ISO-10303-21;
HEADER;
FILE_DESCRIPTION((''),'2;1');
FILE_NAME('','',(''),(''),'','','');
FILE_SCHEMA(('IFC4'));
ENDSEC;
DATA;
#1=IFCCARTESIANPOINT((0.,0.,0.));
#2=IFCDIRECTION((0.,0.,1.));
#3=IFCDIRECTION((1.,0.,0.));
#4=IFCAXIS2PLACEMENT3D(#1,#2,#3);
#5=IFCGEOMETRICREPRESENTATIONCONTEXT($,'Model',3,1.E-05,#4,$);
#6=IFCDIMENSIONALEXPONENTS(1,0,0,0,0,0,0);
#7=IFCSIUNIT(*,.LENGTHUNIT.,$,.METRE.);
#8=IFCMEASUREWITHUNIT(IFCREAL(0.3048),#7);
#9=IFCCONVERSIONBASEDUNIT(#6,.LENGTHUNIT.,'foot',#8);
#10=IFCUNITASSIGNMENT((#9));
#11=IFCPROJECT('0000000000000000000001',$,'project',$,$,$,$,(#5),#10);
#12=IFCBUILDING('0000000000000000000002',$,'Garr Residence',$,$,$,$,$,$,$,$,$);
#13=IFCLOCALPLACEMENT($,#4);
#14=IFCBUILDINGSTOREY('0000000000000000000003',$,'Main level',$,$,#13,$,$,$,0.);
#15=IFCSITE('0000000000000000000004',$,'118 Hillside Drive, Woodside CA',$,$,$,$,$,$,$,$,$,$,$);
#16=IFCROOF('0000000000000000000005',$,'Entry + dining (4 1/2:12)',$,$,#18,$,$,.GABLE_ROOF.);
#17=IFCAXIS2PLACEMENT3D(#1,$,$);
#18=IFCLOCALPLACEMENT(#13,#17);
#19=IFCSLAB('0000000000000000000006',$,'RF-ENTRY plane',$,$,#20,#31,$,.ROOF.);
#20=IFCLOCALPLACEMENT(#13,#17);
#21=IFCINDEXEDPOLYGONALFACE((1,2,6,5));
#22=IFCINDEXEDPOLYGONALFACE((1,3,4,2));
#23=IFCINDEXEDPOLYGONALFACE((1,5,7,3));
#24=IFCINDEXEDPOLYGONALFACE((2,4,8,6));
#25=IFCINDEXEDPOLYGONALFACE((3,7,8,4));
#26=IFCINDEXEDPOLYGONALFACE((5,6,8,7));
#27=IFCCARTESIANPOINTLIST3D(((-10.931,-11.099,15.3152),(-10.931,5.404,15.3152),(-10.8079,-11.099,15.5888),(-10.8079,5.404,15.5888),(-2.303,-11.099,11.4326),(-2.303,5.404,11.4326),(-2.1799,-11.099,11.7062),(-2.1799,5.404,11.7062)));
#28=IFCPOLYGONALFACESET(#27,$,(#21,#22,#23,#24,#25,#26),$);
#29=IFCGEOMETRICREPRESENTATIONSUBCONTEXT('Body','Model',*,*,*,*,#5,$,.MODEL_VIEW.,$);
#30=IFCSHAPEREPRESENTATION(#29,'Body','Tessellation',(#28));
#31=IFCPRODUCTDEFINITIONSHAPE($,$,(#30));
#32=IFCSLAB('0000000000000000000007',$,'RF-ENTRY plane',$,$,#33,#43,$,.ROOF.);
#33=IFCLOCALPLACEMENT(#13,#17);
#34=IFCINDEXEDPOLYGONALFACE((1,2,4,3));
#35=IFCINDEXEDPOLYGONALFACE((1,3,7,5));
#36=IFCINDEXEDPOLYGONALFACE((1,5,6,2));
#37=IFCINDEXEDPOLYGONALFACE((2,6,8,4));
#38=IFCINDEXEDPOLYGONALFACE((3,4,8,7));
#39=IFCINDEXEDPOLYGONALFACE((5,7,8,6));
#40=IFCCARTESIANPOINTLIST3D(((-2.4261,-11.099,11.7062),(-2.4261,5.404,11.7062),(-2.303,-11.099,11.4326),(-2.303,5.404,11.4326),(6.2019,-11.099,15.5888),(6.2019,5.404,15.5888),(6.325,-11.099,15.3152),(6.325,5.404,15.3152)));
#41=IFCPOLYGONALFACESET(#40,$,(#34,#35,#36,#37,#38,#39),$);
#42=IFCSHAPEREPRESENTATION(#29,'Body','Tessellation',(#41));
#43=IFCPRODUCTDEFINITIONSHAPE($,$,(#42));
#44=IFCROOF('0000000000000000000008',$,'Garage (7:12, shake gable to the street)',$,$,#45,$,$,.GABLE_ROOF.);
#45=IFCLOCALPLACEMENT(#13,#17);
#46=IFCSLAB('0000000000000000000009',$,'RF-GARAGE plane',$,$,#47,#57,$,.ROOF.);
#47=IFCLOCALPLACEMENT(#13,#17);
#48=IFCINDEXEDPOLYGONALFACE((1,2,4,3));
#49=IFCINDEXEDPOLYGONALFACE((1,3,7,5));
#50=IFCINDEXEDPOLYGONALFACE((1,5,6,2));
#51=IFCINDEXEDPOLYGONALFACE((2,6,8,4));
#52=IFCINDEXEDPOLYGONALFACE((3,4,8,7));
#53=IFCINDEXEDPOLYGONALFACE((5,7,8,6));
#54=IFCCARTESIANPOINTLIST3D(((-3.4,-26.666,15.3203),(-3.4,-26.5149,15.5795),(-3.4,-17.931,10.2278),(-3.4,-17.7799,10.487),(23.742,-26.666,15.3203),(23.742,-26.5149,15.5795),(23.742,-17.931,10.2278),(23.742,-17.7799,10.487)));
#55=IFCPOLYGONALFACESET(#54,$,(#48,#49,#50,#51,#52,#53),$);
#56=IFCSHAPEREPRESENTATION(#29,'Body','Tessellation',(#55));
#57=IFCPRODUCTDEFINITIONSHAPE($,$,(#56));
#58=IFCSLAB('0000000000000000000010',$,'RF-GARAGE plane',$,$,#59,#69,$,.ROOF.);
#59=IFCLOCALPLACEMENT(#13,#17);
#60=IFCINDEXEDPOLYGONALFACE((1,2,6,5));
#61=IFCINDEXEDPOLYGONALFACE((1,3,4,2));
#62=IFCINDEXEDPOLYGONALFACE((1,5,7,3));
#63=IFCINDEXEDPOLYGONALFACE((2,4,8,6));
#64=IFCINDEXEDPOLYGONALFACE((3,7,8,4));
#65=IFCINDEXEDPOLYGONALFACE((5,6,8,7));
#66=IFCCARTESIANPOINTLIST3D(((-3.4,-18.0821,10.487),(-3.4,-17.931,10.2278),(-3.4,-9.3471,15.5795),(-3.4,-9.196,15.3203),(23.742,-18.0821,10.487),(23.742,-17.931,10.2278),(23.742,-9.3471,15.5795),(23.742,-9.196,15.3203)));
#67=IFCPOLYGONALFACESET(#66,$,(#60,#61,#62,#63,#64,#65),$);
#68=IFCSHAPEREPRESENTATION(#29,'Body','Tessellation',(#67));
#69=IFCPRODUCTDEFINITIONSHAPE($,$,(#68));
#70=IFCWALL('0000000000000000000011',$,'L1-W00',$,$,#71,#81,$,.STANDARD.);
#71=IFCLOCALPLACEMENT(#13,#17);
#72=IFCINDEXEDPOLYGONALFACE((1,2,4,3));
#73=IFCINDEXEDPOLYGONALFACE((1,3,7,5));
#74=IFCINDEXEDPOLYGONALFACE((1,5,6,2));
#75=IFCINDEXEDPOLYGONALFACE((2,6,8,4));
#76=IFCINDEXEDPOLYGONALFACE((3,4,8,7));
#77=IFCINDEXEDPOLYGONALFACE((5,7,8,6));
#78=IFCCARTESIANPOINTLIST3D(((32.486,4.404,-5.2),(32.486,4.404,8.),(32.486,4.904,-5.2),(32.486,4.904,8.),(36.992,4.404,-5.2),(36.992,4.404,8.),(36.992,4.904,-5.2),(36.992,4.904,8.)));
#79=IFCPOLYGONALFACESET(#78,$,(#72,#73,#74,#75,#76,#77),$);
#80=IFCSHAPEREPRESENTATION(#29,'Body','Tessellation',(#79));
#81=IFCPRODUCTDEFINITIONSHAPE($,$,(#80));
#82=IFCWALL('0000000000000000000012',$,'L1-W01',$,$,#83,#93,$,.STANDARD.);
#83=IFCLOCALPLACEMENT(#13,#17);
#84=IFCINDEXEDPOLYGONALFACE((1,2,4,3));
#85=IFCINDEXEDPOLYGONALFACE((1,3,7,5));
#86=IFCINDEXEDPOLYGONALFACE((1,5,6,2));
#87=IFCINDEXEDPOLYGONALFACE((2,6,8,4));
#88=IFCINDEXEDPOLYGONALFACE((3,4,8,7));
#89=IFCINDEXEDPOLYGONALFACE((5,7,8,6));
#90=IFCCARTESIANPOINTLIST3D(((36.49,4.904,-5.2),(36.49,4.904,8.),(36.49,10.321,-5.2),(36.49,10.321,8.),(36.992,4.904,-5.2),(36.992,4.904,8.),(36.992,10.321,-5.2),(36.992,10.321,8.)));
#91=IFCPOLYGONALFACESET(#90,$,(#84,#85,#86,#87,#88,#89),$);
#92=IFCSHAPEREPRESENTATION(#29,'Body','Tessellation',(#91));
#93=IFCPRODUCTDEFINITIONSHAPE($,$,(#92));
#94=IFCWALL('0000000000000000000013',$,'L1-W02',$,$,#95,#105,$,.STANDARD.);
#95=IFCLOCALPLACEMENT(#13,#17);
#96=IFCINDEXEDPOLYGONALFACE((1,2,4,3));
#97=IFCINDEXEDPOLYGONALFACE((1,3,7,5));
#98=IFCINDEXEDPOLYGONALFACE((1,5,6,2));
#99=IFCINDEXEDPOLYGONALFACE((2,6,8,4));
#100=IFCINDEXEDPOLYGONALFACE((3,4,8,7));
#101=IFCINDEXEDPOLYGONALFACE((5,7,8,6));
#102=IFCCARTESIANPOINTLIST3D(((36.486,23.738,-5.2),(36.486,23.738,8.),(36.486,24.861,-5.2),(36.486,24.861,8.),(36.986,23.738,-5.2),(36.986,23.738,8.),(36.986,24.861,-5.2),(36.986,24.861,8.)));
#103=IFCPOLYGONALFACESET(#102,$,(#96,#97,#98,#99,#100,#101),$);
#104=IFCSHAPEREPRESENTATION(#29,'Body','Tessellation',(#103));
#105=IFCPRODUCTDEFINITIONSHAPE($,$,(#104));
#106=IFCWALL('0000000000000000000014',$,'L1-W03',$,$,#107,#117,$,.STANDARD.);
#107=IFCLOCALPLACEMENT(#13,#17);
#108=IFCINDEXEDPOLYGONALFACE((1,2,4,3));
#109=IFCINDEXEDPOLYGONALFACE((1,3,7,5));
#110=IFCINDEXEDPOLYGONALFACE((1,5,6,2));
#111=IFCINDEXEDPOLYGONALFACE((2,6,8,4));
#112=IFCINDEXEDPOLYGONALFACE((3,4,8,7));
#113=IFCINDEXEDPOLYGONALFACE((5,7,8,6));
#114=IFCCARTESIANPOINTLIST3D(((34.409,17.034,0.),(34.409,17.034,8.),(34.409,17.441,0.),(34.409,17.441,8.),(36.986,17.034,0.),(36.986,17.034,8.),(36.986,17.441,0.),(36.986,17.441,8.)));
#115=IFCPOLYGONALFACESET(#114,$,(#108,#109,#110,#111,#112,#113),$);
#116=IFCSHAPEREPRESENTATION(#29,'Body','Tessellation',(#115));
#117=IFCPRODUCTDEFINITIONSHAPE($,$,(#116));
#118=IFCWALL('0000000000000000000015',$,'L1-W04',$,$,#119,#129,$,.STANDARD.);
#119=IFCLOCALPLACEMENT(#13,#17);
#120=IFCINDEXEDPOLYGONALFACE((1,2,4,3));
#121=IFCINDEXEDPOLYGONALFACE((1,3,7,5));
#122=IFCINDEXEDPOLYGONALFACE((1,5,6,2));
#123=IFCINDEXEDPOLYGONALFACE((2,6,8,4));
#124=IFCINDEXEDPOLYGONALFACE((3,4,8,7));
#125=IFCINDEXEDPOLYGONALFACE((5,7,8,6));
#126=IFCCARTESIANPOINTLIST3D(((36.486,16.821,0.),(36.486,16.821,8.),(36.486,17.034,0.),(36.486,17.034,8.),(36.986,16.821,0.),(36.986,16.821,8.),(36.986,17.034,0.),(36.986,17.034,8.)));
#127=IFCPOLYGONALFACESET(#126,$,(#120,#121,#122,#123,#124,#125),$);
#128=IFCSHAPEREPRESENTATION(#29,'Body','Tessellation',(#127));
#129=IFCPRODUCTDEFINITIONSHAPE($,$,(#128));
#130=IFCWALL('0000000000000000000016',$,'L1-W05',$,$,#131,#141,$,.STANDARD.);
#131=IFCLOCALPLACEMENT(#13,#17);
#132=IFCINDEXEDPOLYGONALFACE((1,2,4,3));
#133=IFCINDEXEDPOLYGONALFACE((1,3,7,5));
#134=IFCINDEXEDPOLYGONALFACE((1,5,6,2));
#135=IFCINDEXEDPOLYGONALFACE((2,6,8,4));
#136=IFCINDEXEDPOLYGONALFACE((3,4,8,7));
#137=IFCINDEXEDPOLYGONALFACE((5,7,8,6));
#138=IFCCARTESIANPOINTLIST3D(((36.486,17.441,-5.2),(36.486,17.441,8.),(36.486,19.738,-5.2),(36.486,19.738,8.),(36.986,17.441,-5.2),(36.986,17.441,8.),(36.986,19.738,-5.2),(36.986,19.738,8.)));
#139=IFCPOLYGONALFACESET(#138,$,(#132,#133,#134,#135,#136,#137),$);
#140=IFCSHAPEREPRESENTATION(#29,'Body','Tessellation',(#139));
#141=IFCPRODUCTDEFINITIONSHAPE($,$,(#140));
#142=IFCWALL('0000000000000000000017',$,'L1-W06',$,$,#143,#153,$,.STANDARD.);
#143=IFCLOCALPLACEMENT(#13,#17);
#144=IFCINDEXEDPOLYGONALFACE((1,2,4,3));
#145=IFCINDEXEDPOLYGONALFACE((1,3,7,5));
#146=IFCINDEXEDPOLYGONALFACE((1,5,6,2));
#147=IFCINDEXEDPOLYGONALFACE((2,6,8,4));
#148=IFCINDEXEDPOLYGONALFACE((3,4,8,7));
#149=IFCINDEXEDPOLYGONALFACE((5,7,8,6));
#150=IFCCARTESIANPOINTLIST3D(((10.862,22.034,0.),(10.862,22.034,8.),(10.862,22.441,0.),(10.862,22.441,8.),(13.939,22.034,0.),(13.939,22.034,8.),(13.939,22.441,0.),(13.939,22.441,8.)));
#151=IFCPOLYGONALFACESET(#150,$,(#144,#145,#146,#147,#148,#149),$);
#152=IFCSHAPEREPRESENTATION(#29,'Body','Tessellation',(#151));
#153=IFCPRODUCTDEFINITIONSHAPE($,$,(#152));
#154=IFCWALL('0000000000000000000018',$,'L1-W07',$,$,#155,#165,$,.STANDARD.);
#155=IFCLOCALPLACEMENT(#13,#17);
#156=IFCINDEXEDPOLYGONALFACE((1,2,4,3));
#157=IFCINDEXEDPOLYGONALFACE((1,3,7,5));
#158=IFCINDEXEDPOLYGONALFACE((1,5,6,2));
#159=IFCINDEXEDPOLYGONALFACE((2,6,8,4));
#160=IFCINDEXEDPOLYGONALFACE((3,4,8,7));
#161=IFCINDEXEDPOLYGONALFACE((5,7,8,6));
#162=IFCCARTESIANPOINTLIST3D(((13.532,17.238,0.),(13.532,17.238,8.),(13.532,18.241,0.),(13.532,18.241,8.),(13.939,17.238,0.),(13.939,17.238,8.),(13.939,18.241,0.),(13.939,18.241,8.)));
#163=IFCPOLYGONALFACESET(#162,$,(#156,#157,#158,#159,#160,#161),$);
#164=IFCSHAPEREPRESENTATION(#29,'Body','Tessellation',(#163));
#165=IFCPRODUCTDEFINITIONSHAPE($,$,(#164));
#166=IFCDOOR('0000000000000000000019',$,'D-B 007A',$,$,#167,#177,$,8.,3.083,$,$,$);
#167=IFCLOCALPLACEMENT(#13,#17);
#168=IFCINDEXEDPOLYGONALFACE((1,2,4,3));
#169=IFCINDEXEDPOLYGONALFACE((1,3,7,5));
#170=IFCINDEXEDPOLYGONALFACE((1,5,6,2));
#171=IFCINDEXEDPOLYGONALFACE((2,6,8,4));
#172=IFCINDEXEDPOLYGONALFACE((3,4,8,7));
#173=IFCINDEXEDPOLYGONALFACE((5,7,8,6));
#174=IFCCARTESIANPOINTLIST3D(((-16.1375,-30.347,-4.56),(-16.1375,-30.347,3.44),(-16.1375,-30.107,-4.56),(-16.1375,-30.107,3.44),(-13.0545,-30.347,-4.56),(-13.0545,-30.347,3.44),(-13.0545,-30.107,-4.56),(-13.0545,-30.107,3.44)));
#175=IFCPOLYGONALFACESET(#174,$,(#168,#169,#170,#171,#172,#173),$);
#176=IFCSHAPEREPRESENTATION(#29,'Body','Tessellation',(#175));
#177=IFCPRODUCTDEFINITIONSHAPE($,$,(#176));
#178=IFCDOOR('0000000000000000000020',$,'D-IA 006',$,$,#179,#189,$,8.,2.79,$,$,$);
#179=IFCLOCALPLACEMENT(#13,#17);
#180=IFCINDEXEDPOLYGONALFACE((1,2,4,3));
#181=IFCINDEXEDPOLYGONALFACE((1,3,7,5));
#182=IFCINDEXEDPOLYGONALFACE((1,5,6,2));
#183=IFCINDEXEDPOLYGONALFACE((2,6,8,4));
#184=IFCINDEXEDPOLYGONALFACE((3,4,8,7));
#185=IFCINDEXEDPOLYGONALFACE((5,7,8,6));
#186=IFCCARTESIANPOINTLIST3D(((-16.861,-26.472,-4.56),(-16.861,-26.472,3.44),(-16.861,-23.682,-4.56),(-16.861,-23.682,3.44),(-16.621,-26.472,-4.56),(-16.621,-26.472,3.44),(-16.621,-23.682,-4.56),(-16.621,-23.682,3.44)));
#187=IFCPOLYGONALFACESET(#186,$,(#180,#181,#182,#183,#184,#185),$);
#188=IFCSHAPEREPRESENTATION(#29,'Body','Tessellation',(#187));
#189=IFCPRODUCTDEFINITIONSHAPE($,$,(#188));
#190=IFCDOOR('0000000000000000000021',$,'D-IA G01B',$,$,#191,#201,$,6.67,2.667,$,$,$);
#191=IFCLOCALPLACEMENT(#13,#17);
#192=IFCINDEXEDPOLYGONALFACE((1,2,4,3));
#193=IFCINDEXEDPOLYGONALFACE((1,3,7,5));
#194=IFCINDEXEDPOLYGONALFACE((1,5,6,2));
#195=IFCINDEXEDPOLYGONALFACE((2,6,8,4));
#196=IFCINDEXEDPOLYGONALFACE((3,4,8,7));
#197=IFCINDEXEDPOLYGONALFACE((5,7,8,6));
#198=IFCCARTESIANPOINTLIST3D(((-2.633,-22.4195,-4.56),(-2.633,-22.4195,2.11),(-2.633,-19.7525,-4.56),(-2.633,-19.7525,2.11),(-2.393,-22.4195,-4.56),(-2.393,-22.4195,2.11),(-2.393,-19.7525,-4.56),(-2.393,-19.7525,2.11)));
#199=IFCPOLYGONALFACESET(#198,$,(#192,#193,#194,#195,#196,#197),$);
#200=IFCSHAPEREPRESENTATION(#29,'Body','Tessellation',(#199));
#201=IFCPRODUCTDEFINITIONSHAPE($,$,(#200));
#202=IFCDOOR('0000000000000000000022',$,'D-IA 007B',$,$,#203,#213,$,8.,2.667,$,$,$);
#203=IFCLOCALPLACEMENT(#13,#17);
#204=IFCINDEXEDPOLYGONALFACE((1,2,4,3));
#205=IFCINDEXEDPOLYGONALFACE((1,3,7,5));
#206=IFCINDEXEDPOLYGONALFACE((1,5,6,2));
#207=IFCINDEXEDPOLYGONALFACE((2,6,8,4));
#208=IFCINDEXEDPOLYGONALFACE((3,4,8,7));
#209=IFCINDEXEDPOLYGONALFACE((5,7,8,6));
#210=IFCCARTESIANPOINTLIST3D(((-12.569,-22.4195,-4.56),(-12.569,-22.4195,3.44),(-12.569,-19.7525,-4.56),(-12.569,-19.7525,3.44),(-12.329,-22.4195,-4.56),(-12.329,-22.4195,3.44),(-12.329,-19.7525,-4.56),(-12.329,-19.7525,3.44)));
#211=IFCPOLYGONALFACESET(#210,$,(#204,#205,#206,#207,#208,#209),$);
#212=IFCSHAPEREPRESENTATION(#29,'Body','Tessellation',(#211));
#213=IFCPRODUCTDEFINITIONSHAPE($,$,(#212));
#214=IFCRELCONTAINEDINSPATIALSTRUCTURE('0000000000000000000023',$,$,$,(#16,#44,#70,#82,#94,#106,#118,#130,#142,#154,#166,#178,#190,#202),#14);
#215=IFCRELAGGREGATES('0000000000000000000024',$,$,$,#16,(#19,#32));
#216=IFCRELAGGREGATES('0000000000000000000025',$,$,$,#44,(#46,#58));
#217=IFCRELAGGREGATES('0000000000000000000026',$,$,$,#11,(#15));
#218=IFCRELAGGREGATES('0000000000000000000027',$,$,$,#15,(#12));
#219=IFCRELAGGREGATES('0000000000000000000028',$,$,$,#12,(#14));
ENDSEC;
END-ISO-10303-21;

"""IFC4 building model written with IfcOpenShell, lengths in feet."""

from ifc_helpers import new_model, entity, si_unit, converted_unit, frame, origin, origin_with_axes, place, context, subcontext, project, spatial, polyline, outline, extrude, element, aggregate, save


model = new_model("IFC4")

# Units and contexts
model_context = context("Model", 3, precision=1e-05, world=origin_with_axes())
body_context = subcontext(model_context, "Body", "Model", "MODEL_VIEW")
ifc_project = project(units=[converted_unit("LENGTHUNIT", "foot", entity("IfcReal", 0.3048), si_unit("LENGTHUNIT", "METRE"), dimensions=[1, 0, 0, 0, 0, 0, 0])], contexts=[model_context])

# Site, building, storey
site = spatial("IfcSite", under=ifc_project, Name="118 Hillside Drive, Woodside CA")
building = spatial("IfcBuilding", under=site, Name="Garr Residence")
storey_placement = place(None, origin_with_axes())
storey = spatial("IfcBuildingStorey", under=building, at=storey_placement, Name="Main level", Elevation=0.0)

# Roofs, slabs
roof_1 = element("IfcRoof", 1, inside=storey, Name="Entry + dining (4 1/2:12)", PredefinedType="GABLE_ROOF")
slab_1_placement = place(None, frame((-2.303, -11.099, 11.4326), z_axis=(0.410365, 0.0, 0.911922), x_axis=(0.0, 1.0, 0.0)))
slab_1 = element("IfcSlab", 2, at=slab_1_placement, Name="RF-ENTRY plane", PredefinedType="ROOF", context=body_context, shape_type="SweptSolid", body=[
    extrude(outline(polyline([(0.0, 0.0), (16.503, 0.0), (16.503, 9.4613), (0.0, 9.4613), (0.0, 0.0)])), origin(), (0.0, 0.0, 1.0), 0.3),
])
slab_2_placement = place(None, frame((-2.303, -11.099, 11.4326), z_axis=(-0.410365, 0.0, 0.911922), x_axis=(0.0, 1.0, 0.0)))
slab_2 = element("IfcSlab", 3, at=slab_2_placement, Name="RF-ENTRY plane", PredefinedType="ROOF", context=body_context, shape_type="SweptSolid", body=[
    extrude(outline(polyline([(0.0, 0.0), (16.503, 0.0), (16.503, -9.4613), (0.0, -9.4613), (0.0, 0.0)])), origin(), (0.0, 0.0, 1.0), 0.3),
])
aggregate(roof_1, [slab_1, slab_2])
roof_2 = element("IfcRoof", 4, inside=storey, Name="Garage (7:12, shake gable to the street)", PredefinedType="GABLE_ROOF")
slab_3_placement = place(None, frame((-3.4, -17.931, 10.2278), z_axis=(0.0, 0.503656, 0.863904), x_axis=(1.0, 0.0, 0.0)))
slab_3 = element("IfcSlab", 5, at=slab_3_placement, Name="RF-GARAGE plane", PredefinedType="ROOF", context=body_context, shape_type="SweptSolid", body=[
    extrude(outline(polyline([(0.0, 0.0), (27.142, 0.0), (27.142, -10.1111), (0.0, -10.1111), (0.0, 0.0)])), origin(), (0.0, 0.0, 1.0), 0.3),
])
slab_4_placement = place(None, frame((-3.4, -17.931, 10.2278), z_axis=(0.0, -0.503656, 0.863904), x_axis=(1.0, 0.0, 0.0)))
slab_4 = element("IfcSlab", 6, at=slab_4_placement, Name="RF-GARAGE plane", PredefinedType="ROOF", context=body_context, shape_type="SweptSolid", body=[
    extrude(outline(polyline([(0.0, 0.0), (27.142, 0.0), (27.142, 10.1111), (0.0, 10.1111), (0.0, 0.0)])), origin(), (0.0, 0.0, 1.0), 0.3),
])
aggregate(roof_2, [slab_3, slab_4])

# Walls
wall_1_placement = place(storey_placement, frame((0.0, 0.0, -5.2), z_axis=(0.0, 0.0, 1.0), x_axis=(1.0, 0.0, 0.0)))
element("IfcWall", 7, at=wall_1_placement, inside=storey, Name="L1-W00", PredefinedType="STANDARD", context=body_context, shape_type="SweptSolid", body=[
    extrude(outline(polyline([(36.992, 4.404), (36.992, 4.904), (32.486, 4.904), (32.486, 4.404), (36.992, 4.404)])), origin(), (0.0, 0.0, 1.0), 13.2),
])
wall_2_placement = place(storey_placement, frame((0.0, 0.0, -5.2), z_axis=(0.0, 0.0, 1.0), x_axis=(1.0, 0.0, 0.0)))
element("IfcWall", 8, at=wall_2_placement, inside=storey, Name="L1-W01", PredefinedType="STANDARD", context=body_context, shape_type="SweptSolid", body=[
    extrude(outline(polyline([(36.992, 4.904), (36.992, 10.321), (36.49, 10.321), (36.49, 4.904), (36.992, 4.904)])), origin(), (0.0, 0.0, 1.0), 13.2),
])
wall_3_placement = place(storey_placement, frame((0.0, 0.0, -5.2), z_axis=(0.0, 0.0, 1.0), x_axis=(1.0, 0.0, 0.0)))
element("IfcWall", 9, at=wall_3_placement, inside=storey, Name="L1-W02", PredefinedType="STANDARD", context=body_context, shape_type="SweptSolid", body=[
    extrude(outline(polyline([(36.986, 23.738), (36.986, 24.861), (36.486, 24.861), (36.486, 23.738), (36.986, 23.738)])), origin(), (0.0, 0.0, 1.0), 13.2),
])
wall_4_placement = place(storey_placement, origin_with_axes())
element("IfcWall", 10, at=wall_4_placement, inside=storey, Name="L1-W03", PredefinedType="STANDARD", context=body_context, shape_type="SweptSolid", body=[
    extrude(outline(polyline([(36.986, 17.034), (36.986, 17.441), (34.409, 17.441), (34.409, 17.034), (36.986, 17.034)])), origin(), (0.0, 0.0, 1.0), 8.0),
])
wall_5_placement = place(storey_placement, origin_with_axes())
element("IfcWall", 11, at=wall_5_placement, inside=storey, Name="L1-W04", PredefinedType="STANDARD", context=body_context, shape_type="SweptSolid", body=[
    extrude(outline(polyline([(36.986, 16.821), (36.986, 17.034), (36.486, 17.034), (36.486, 16.821), (36.986, 16.821)])), origin(), (0.0, 0.0, 1.0), 8.0),
])
wall_6_placement = place(storey_placement, frame((0.0, 0.0, -5.2), z_axis=(0.0, 0.0, 1.0), x_axis=(1.0, 0.0, 0.0)))
element("IfcWall", 12, at=wall_6_placement, inside=storey, Name="L1-W05", PredefinedType="STANDARD", context=body_context, shape_type="SweptSolid", body=[
    extrude(outline(polyline([(36.986, 17.441), (36.986, 19.738), (36.486, 19.738), (36.486, 17.441), (36.986, 17.441)])), origin(), (0.0, 0.0, 1.0), 13.2),
])
wall_7_placement = place(storey_placement, origin_with_axes())
element("IfcWall", 13, at=wall_7_placement, inside=storey, Name="L1-W06", PredefinedType="STANDARD", context=body_context, shape_type="SweptSolid", body=[
    extrude(outline(polyline([(13.939, 22.034), (13.939, 22.441), (10.862, 22.441), (10.862, 22.034), (13.939, 22.034)])), origin(), (0.0, 0.0, 1.0), 8.0),
])
wall_8_placement = place(storey_placement, origin_with_axes())
element("IfcWall", 14, at=wall_8_placement, inside=storey, Name="L1-W07", PredefinedType="STANDARD", context=body_context, shape_type="SweptSolid", body=[
    extrude(outline(polyline([(13.939, 17.238), (13.939, 18.241), (13.532, 18.241), (13.532, 17.238), (13.939, 17.238)])), origin(), (0.0, 0.0, 1.0), 8.0),
])

# Doors
door_1_placement = place(storey_placement, frame((-14.596, -30.227, -4.56), z_axis=(0.0, 0.0, 1.0), x_axis=(1.0, 0.0, 0.0)))
element("IfcDoor", 15, at=door_1_placement, inside=storey, Name="D-B 007A", OverallHeight=8.0, OverallWidth=3.083, context=body_context, shape_type="SweptSolid", body=[
    extrude(outline(polyline([(-1.5415, -0.12), (1.5415, -0.12), (1.5415, 0.12), (-1.5415, 0.12), (-1.5415, -0.12)])), origin(), (0.0, 0.0, 1.0), 8.0),
])
door_2_placement = place(storey_placement, frame((-16.741, -25.077, -4.56), z_axis=(0.0, 0.0, 1.0), x_axis=(0.0, 1.0, 0.0)))
element("IfcDoor", 16, at=door_2_placement, inside=storey, Name="D-IA 006", OverallHeight=8.0, OverallWidth=2.79, context=body_context, shape_type="SweptSolid", body=[
    extrude(outline(polyline([(-1.395, -0.12), (1.395, -0.12), (1.395, 0.12), (-1.395, 0.12), (-1.395, -0.12)])), origin(), (0.0, 0.0, 1.0), 8.0),
])
door_3_placement = place(storey_placement, frame((-2.513, -21.086, -4.56), z_axis=(0.0, 0.0, 1.0), x_axis=(0.0, 1.0, 0.0)))
element("IfcDoor", 17, at=door_3_placement, inside=storey, Name="D-IA G01B", OverallHeight=6.67, OverallWidth=2.667, context=body_context, shape_type="SweptSolid", body=[
    extrude(outline(polyline([(-1.3335, -0.12), (1.3335, -0.12), (1.3335, 0.12), (-1.3335, 0.12), (-1.3335, -0.12)])), origin(), (0.0, 0.0, 1.0), 6.67),
])
door_4_placement = place(storey_placement, frame((-12.449, -21.086, -4.56), z_axis=(0.0, 0.0, 1.0), x_axis=(0.0, 1.0, 0.0)))
element("IfcDoor", 18, at=door_4_placement, inside=storey, Name="D-IA 007B", OverallHeight=8.0, OverallWidth=2.667, context=body_context, shape_type="SweptSolid", body=[
    extrude(outline(polyline([(-1.3335, -0.12), (1.3335, -0.12), (1.3335, 0.12), (-1.3335, 0.12), (-1.3335, -0.12)])), origin(), (0.0, 0.0, 1.0), 8.0),
])

save(model, "model.ifc")
